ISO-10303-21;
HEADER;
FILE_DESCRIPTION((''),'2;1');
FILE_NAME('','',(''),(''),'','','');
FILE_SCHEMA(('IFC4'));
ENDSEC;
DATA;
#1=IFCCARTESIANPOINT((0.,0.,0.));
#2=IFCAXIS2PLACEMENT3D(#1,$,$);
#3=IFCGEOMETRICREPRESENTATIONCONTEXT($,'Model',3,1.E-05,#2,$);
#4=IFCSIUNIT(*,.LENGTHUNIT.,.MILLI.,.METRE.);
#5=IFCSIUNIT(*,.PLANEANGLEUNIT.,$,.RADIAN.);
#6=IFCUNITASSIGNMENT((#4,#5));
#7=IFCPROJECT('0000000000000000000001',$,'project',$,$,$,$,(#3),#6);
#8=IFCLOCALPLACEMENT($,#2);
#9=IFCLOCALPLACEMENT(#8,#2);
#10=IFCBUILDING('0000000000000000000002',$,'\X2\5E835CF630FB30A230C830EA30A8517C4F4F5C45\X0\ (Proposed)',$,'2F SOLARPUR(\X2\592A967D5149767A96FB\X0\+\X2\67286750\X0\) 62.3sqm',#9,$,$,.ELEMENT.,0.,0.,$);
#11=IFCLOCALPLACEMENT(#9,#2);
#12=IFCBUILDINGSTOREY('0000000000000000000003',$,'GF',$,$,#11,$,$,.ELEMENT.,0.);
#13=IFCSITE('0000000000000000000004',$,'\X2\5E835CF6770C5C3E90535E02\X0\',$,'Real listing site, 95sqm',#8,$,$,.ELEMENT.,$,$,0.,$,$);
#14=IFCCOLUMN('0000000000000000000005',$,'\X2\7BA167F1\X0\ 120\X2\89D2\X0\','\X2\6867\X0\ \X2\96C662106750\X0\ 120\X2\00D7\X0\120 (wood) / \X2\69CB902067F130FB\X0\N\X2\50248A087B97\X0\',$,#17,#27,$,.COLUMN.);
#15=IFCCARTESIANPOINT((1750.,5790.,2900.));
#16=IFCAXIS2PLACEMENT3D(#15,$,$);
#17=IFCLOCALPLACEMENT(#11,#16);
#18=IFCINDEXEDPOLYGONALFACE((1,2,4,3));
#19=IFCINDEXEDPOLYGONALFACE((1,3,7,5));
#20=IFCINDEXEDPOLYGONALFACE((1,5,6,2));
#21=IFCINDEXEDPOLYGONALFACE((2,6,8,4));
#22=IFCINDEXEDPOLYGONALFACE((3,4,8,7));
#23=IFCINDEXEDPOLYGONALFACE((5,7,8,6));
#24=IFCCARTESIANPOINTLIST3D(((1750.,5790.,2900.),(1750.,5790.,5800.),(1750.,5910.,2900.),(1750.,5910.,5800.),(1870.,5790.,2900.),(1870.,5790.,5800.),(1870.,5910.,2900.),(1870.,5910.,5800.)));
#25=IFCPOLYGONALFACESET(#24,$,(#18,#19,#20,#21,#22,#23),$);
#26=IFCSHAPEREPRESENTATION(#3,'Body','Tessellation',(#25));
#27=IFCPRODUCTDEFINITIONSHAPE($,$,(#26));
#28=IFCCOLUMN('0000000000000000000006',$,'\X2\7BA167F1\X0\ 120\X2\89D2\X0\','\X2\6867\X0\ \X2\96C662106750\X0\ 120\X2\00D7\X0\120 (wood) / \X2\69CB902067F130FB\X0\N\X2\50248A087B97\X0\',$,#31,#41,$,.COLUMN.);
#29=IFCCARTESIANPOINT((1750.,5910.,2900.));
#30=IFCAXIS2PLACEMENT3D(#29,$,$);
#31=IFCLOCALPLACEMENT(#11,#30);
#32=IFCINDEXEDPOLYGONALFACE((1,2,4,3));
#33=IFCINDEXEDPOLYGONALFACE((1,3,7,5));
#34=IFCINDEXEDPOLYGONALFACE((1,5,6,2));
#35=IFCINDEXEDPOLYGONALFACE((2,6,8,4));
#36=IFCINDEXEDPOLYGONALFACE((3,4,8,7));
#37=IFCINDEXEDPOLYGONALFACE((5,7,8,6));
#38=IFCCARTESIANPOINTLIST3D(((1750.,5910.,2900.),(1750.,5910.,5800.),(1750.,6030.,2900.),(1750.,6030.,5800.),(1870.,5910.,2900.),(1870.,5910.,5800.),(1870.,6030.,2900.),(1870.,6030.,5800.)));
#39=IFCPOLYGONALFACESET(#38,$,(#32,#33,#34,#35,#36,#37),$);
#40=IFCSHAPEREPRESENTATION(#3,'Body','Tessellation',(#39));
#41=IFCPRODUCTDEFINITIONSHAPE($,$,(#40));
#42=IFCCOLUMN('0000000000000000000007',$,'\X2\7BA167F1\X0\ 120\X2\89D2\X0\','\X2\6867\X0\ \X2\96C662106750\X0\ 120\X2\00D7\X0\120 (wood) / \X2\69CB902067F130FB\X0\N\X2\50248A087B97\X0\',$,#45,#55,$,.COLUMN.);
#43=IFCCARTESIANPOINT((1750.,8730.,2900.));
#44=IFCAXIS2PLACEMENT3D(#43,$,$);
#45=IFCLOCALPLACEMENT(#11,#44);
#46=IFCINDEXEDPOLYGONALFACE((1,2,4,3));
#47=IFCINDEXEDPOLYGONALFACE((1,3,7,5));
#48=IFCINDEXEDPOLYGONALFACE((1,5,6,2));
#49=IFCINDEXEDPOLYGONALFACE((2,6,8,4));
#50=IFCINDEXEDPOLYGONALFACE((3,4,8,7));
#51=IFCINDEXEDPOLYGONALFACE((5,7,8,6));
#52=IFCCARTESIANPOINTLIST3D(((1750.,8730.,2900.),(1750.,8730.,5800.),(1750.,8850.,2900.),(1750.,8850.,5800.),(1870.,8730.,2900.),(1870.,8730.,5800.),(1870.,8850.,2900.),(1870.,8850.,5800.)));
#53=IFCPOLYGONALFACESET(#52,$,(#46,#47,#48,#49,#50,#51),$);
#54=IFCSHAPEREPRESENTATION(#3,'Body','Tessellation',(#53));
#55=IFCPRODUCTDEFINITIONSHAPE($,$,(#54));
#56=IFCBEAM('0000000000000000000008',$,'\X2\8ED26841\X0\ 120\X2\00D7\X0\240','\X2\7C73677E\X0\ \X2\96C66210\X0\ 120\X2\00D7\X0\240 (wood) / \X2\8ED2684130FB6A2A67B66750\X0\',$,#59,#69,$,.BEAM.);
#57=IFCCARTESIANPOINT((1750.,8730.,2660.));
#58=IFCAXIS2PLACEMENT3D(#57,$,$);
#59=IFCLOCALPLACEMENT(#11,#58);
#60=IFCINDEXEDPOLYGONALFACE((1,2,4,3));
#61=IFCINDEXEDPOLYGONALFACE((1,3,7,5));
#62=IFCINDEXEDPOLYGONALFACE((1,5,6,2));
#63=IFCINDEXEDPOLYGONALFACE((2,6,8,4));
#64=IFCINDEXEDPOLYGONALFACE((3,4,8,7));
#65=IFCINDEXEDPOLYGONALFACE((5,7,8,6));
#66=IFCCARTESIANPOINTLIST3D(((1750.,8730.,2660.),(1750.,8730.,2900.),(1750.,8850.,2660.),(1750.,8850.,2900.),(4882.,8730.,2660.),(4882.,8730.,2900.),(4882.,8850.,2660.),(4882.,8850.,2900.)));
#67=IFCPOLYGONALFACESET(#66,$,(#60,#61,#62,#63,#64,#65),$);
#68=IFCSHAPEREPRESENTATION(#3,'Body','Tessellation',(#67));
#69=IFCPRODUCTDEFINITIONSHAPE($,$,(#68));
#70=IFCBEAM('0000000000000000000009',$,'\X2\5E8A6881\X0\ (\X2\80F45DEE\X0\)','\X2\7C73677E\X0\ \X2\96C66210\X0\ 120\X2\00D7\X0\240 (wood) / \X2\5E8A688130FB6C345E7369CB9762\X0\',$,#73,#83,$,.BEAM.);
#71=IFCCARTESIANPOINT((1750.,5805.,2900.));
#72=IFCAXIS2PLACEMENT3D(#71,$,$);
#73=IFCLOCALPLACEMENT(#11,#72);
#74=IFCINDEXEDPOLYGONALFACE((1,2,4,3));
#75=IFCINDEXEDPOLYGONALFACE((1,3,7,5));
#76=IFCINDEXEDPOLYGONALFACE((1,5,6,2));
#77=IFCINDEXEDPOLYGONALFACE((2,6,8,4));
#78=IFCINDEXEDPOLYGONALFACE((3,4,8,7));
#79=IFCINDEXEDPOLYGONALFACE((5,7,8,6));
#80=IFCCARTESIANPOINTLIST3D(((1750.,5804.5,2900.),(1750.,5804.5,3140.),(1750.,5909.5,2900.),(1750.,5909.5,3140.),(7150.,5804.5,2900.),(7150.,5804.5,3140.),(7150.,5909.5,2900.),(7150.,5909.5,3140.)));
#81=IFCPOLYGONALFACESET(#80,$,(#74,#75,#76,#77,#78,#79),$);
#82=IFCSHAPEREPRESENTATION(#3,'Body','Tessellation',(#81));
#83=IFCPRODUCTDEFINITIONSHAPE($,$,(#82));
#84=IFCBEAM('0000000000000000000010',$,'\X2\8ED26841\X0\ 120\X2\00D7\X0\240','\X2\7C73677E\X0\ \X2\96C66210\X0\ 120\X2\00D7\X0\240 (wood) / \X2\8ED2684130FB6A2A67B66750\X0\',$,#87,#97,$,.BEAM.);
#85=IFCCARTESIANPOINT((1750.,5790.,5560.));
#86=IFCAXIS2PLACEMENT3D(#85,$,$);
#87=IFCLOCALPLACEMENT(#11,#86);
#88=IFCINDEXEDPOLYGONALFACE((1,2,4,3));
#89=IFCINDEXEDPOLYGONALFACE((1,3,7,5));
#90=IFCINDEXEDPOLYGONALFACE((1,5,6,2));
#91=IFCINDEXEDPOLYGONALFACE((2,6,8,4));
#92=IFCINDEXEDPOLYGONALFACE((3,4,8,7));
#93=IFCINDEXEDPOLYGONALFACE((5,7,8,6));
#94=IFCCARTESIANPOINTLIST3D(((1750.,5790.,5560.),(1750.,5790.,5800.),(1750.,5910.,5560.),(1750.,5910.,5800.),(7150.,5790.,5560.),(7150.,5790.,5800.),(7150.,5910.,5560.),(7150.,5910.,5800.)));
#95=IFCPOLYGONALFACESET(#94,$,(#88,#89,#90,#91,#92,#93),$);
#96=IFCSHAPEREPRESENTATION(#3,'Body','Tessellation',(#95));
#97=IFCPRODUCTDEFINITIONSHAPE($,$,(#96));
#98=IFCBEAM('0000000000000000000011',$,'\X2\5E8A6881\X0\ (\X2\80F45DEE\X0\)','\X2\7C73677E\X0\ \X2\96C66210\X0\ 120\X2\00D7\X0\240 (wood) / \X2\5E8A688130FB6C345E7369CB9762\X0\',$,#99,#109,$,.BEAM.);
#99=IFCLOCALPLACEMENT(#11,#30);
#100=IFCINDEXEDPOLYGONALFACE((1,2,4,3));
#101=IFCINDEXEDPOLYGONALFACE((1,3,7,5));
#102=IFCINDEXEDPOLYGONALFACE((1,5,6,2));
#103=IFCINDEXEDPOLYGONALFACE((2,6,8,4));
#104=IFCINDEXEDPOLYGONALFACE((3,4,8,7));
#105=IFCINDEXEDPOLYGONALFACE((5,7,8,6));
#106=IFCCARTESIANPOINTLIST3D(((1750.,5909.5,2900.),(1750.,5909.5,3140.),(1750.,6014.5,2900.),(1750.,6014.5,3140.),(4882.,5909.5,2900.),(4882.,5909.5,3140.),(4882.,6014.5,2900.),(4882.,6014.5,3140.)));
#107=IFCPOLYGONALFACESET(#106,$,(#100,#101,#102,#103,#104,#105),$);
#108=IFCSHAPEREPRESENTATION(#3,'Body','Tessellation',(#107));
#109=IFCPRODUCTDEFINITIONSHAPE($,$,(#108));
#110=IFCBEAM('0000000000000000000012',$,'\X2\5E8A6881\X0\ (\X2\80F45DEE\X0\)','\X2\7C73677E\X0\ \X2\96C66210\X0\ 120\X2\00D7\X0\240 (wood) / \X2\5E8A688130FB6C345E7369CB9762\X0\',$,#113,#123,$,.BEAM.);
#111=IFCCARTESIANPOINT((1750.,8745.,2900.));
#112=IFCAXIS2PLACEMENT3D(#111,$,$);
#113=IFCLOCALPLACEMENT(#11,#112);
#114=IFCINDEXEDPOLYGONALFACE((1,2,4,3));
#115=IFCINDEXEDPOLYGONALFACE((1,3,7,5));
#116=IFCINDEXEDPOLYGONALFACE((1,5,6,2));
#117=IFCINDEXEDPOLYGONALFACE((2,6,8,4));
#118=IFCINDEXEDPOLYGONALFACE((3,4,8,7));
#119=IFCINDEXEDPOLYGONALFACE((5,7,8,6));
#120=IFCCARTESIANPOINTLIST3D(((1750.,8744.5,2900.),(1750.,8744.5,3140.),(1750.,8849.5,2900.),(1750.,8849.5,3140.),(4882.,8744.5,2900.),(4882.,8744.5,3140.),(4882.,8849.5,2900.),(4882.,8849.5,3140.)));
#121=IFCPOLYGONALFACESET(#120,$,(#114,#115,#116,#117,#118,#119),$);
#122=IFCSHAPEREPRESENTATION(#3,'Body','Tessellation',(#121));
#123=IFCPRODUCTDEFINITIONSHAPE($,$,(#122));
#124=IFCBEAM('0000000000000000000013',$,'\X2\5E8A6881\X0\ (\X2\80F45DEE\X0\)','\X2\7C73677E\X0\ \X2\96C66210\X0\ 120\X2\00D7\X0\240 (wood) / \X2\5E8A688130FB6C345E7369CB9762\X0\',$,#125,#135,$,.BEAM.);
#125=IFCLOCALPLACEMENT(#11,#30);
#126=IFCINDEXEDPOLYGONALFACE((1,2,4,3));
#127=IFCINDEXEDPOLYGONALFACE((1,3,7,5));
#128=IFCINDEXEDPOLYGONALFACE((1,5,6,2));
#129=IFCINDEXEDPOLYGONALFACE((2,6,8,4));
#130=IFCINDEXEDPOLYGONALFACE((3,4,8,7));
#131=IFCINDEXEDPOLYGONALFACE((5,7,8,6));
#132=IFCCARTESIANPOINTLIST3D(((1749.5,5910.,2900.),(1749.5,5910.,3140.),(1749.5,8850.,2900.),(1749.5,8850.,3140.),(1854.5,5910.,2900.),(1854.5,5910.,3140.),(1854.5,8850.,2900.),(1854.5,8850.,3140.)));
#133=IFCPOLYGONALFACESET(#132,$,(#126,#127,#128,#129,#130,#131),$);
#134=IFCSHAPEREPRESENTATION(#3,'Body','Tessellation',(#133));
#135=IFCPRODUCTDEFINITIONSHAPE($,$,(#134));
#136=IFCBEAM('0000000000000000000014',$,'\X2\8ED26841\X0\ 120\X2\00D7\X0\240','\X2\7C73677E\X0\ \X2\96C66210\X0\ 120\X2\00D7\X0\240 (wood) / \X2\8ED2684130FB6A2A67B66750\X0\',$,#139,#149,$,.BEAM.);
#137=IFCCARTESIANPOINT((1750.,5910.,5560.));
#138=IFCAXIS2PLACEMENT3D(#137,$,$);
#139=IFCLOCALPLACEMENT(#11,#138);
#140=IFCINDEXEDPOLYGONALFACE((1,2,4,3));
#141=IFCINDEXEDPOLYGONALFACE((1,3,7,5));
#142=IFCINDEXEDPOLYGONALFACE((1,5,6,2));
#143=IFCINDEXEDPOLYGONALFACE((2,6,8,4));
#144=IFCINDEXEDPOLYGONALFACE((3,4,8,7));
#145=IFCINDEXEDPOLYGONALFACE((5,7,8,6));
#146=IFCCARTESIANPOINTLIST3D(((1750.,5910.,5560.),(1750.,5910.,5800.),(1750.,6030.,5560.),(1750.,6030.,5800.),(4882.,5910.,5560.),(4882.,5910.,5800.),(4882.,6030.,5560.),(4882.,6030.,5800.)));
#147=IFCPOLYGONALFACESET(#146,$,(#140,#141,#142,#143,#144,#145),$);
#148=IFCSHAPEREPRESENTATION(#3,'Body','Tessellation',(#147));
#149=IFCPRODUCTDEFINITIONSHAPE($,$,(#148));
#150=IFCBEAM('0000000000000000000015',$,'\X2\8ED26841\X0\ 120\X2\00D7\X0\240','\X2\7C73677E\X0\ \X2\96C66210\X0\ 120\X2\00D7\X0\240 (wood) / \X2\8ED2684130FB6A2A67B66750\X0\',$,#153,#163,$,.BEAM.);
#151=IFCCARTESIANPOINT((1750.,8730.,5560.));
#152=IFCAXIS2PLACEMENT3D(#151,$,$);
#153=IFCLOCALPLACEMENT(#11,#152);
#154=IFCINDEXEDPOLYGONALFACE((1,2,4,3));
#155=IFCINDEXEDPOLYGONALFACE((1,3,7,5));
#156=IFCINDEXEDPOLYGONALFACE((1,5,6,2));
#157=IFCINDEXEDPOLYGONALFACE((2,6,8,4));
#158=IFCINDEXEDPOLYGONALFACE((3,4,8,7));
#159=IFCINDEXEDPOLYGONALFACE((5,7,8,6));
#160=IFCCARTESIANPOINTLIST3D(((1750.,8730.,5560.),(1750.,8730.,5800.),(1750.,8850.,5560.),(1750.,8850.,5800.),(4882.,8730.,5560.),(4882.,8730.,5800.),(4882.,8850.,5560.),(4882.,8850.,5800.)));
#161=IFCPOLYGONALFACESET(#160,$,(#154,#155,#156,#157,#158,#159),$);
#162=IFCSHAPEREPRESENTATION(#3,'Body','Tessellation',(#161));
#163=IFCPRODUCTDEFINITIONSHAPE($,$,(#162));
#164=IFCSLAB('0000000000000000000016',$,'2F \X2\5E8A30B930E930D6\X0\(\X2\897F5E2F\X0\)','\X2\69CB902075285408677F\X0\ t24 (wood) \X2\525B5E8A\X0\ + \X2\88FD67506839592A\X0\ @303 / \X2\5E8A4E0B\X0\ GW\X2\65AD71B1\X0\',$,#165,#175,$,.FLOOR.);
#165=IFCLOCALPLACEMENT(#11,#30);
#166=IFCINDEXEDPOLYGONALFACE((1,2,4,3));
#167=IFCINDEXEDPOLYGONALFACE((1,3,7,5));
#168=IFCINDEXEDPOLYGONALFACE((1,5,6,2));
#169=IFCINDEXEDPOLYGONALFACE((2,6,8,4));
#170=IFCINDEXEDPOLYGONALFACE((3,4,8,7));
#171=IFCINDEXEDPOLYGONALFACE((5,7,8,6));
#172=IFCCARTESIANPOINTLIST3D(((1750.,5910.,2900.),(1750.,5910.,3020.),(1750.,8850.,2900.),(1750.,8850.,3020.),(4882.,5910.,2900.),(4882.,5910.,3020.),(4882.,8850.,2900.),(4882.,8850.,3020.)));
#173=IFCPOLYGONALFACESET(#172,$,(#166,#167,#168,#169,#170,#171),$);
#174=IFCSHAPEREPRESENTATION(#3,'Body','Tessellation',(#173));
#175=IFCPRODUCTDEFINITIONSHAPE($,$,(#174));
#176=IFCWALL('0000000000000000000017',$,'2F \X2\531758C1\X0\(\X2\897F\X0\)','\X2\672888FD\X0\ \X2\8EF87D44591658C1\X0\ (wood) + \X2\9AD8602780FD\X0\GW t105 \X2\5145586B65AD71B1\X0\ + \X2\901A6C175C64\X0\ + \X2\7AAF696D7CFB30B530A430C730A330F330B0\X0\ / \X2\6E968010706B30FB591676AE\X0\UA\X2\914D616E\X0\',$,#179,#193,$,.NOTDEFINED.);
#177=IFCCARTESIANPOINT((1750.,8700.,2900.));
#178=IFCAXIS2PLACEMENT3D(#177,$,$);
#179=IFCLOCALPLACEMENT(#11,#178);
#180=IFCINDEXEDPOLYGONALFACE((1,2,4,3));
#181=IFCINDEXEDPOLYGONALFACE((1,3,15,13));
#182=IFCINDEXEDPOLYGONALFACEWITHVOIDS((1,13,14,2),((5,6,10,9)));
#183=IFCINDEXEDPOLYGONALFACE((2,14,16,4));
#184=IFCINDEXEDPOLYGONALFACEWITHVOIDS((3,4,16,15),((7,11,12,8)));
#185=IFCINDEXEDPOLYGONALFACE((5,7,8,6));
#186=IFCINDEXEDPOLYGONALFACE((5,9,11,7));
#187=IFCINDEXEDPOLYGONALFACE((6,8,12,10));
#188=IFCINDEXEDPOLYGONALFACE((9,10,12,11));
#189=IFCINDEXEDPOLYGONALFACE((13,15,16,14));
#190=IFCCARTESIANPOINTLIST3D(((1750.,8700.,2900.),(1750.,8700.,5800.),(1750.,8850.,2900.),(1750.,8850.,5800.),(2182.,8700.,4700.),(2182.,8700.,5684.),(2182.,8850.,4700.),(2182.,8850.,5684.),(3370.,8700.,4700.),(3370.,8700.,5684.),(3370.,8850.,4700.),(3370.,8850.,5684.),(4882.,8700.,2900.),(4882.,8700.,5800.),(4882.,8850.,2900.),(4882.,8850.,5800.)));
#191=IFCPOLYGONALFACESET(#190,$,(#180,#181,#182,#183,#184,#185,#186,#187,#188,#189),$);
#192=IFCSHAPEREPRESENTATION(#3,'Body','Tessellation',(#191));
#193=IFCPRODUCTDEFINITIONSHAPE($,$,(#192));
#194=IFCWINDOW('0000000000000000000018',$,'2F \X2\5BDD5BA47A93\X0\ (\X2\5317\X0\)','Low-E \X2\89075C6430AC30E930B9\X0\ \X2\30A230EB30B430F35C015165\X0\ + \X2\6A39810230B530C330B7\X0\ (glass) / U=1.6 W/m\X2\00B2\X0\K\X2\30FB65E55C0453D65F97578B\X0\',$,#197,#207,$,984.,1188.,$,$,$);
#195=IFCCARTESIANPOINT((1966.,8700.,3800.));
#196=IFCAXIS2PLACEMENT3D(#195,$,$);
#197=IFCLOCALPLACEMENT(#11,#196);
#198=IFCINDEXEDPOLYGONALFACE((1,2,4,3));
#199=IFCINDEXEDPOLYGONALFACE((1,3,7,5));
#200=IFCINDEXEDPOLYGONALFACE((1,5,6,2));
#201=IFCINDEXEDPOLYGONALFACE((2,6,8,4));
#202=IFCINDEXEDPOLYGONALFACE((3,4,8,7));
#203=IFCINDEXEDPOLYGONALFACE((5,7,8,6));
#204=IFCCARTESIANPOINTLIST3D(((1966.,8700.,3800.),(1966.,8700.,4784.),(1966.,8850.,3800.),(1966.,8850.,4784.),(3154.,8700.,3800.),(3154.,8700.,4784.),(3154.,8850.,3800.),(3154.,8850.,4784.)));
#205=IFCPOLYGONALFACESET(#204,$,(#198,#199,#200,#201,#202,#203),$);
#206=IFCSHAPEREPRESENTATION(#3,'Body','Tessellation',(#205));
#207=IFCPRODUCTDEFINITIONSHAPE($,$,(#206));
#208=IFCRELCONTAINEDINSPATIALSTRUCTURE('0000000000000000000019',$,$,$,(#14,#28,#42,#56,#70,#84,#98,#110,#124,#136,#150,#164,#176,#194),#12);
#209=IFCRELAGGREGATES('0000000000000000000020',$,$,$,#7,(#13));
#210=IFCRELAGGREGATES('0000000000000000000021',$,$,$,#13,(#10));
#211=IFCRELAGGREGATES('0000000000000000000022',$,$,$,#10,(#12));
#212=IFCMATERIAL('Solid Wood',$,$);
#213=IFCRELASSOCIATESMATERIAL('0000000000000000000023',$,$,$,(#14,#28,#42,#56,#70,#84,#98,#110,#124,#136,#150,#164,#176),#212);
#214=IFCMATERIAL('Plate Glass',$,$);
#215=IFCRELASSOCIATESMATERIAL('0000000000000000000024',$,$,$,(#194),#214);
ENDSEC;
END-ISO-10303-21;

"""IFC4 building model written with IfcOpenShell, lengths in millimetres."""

from ifc_helpers import new_model, si_unit, frame, frame_2d, origin, place, context, project, spatial, rectangle, extrude, material, element, fill, save


model = new_model("IFC4")

# Units and contexts
model_context = context("Model", 3, precision=1e-05, world=origin())
ifc_project = project(units=[si_unit("LENGTHUNIT", "METRE", prefix="MILLI"), si_unit("PLANEANGLEUNIT", "RADIAN")], contexts=[model_context])

# Site, building, storey
site_placement = place(None, origin())
site = spatial("IfcSite", under=ifc_project, at=site_placement, Name="広島県尾道市", ObjectType="Real listing site, 95sqm", CompositionType="ELEMENT", RefElevation=0.0)
building_placement = place(site_placement, origin())
building = spatial("IfcBuilding", under=site, at=building_placement, Name="広島・アトリエ兼住居 (Proposed)", ObjectType="2F SOLARPUR(太陽光発電+木材) 62.3sqm", CompositionType="ELEMENT", ElevationOfRefHeight=0.0, ElevationOfTerrain=0.0)
storey_placement = place(building_placement, origin())
storey = spatial("IfcBuildingStorey", under=building, at=storey_placement, Name="GF", CompositionType="ELEMENT", Elevation=0.0)

# Columns
ifc_material_1 = material(Name="Solid Wood")
column_1_placement = place(storey_placement, frame((1750.0, 5790.0, 2900.0)))
element("IfcColumn", 1, at=column_1_placement, inside=storey, material=ifc_material_1, Name="管柱 120角", Description="桧 集成材 120×120 (wood) / 構造柱・N値計算", PredefinedType="COLUMN", context=model_context, shape_type="SweptSolid", body=[
    extrude(rectangle(XDim=120.0, YDim=120.0, at=frame_2d((60.0, 60.0))), frame((1750.0, 5790.0, 2900.0)), (0.0, 0.0, 1.0), 2900.0),
])
column_2_placement = place(storey_placement, frame((1750.0, 5910.0, 2900.0)))
element("IfcColumn", 2, at=column_2_placement, inside=storey, material=ifc_material_1, Name="管柱 120角", Description="桧 集成材 120×120 (wood) / 構造柱・N値計算", PredefinedType="COLUMN", context=model_context, shape_type="SweptSolid", body=[
    extrude(rectangle(XDim=120.0, YDim=120.0, at=frame_2d((60.0, 60.0))), frame((1750.0, 5910.0, 2900.0)), (0.0, 0.0, 1.0), 2900.0),
])
column_3_placement = place(storey_placement, frame((1750.0, 8730.0, 2900.0)))
element("IfcColumn", 3, at=column_3_placement, inside=storey, material=ifc_material_1, Name="管柱 120角", Description="桧 集成材 120×120 (wood) / 構造柱・N値計算", PredefinedType="COLUMN", context=model_context, shape_type="SweptSolid", body=[
    extrude(rectangle(XDim=120.0, YDim=120.0, at=frame_2d((60.0, 60.0))), frame((1750.0, 8730.0, 2900.0)), (0.0, 0.0, 1.0), 2900.0),
])

# Beams
beam_1_placement = place(storey_placement, frame((1750.0, 8730.0, 2660.0)))
element("IfcBeam", 4, at=beam_1_placement, inside=storey, material=ifc_material_1, Name="軒桁 120×240", Description="米松 集成 120×240 (wood) / 軒桁・横架材", PredefinedType="BEAM", context=model_context, shape_type="SweptSolid", body=[
    extrude(rectangle(XDim=3132.0, YDim=120.0, at=frame_2d((1566.0, 60.0))), frame((1750.0, 8730.0, 2660.0)), (0.0, 0.0, 1.0), 240.0),
])
beam_2_placement = place(storey_placement, frame((1750.0, 5805.0, 2900.0)))
element("IfcBeam", 5, at=beam_2_placement, inside=storey, material=ifc_material_1, Name="床梁 (胴差)", Description="米松 集成 120×240 (wood) / 床梁・水平構面", PredefinedType="BEAM", context=model_context, shape_type="SweptSolid", body=[
    extrude(rectangle(XDim=5400.0, YDim=105.0, at=frame_2d((2700.0, 52.0))), frame((1750.0, 5805.0, 2900.0)), (0.0, 0.0, 1.0), 240.0),
])
beam_3_placement = place(storey_placement, frame((1750.0, 5790.0, 5560.0)))
element("IfcBeam", 6, at=beam_3_placement, inside=storey, material=ifc_material_1, Name="軒桁 120×240", Description="米松 集成 120×240 (wood) / 軒桁・横架材", PredefinedType="BEAM", context=model_context, shape_type="SweptSolid", body=[
    extrude(rectangle(XDim=5400.0, YDim=120.0, at=frame_2d((2700.0, 60.0))), frame((1750.0, 5790.0, 5560.0)), (0.0, 0.0, 1.0), 240.0),
])
beam_4_placement = place(storey_placement, frame((1750.0, 5910.0, 2900.0)))
element("IfcBeam", 7, at=beam_4_placement, inside=storey, material=ifc_material_1, Name="床梁 (胴差)", Description="米松 集成 120×240 (wood) / 床梁・水平構面", PredefinedType="BEAM", context=model_context, shape_type="SweptSolid", body=[
    extrude(rectangle(XDim=3132.0, YDim=105.0, at=frame_2d((1566.0, 52.0))), frame((1750.0, 5910.0, 2900.0)), (0.0, 0.0, 1.0), 240.0),
])
beam_5_placement = place(storey_placement, frame((1750.0, 8745.0, 2900.0)))
element("IfcBeam", 8, at=beam_5_placement, inside=storey, material=ifc_material_1, Name="床梁 (胴差)", Description="米松 集成 120×240 (wood) / 床梁・水平構面", PredefinedType="BEAM", context=model_context, shape_type="SweptSolid", body=[
    extrude(rectangle(XDim=3132.0, YDim=105.0, at=frame_2d((1566.0, 52.0))), frame((1750.0, 8745.0, 2900.0)), (0.0, 0.0, 1.0), 240.0),
])
beam_6_placement = place(storey_placement, frame((1750.0, 5910.0, 2900.0)))
element("IfcBeam", 9, at=beam_6_placement, inside=storey, material=ifc_material_1, Name="床梁 (胴差)", Description="米松 集成 120×240 (wood) / 床梁・水平構面", PredefinedType="BEAM", context=model_context, shape_type="SweptSolid", body=[
    extrude(rectangle(XDim=105.0, YDim=2940.0, at=frame_2d((52.0, 1470.0))), frame((1750.0, 5910.0, 2900.0)), (0.0, 0.0, 1.0), 240.0),
])
beam_7_placement = place(storey_placement, frame((1750.0, 5910.0, 5560.0)))
element("IfcBeam", 10, at=beam_7_placement, inside=storey, material=ifc_material_1, Name="軒桁 120×240", Description="米松 集成 120×240 (wood) / 軒桁・横架材", PredefinedType="BEAM", context=model_context, shape_type="SweptSolid", body=[
    extrude(rectangle(XDim=3132.0, YDim=120.0, at=frame_2d((1566.0, 60.0))), frame((1750.0, 5910.0, 5560.0)), (0.0, 0.0, 1.0), 240.0),
])
beam_8_placement = place(storey_placement, frame((1750.0, 8730.0, 5560.0)))
element("IfcBeam", 11, at=beam_8_placement, inside=storey, material=ifc_material_1, Name="軒桁 120×240", Description="米松 集成 120×240 (wood) / 軒桁・横架材", PredefinedType="BEAM", context=model_context, shape_type="SweptSolid", body=[
    extrude(rectangle(XDim=3132.0, YDim=120.0, at=frame_2d((1566.0, 60.0))), frame((1750.0, 8730.0, 5560.0)), (0.0, 0.0, 1.0), 240.0),
])

# Slab
slab_placement = place(storey_placement, frame((1750.0, 5910.0, 2900.0)))
element("IfcSlab", 12, at=slab_placement, inside=storey, material=ifc_material_1, Name="2F 床スラブ(西帯)", Description="構造用合板 t24 (wood) 剛床 + 製材根太 @303 / 床下 GW断熱", PredefinedType="FLOOR", context=model_context, shape_type="SweptSolid", body=[
    extrude(rectangle(XDim=3132.0, YDim=2940.0, at=frame_2d((1566.0, 1470.0))), frame((1750.0, 5910.0, 2900.0)), (0.0, 0.0, 1.0), 120.0),
])

# Wall, opening, window
wall_1_placement = place(storey_placement, frame((1750.0, 8700.0, 2900.0)))
wall_1 = element("IfcWall", 13, at=wall_1_placement, inside=storey, material=ifc_material_1, Name="2F 北壁(西)", Description="木製 軸組外壁 (wood) + 高性能GW t105 充填断熱 + 通気層 + 窯業系サイディング / 準耐火・外皮UA配慮", PredefinedType="NOTDEFINED", context=model_context, shape_type="SweptSolid", body=[
    extrude(rectangle(XDim=3132.0, YDim=150.0, at=frame_2d((1566.0, 75.0))), frame((1750.0, 8700.0, 2900.0)), (0.0, 0.0, 1.0), 2900.0),
])
opening_placement = place(storey_placement, frame((1966.0, 8700.0, 3800.0)))
opening = element("IfcOpeningElement", 14, at=opening_placement, cuts=wall_1, PredefinedType="NOTDEFINED", context=model_context, shape_type="SweptSolid", body=[
    extrude(rectangle(XDim=1188.0, YDim=150.0, at=frame_2d((594.0, 75.0))), frame((1966.0, 8700.0, 3800.0)), (0.0, 0.0, 1.0), 984.0),
])
ifc_material_2 = material(Name="Plate Glass")
window_placement = place(storey_placement, frame((1966.0, 8700.0, 3800.0)))
window = element("IfcWindow", 15, at=window_placement, inside=storey, material=ifc_material_2, Name="2F 寝室窓 (北)", Description="Low-E 複層ガラス アルゴン封入 + 樹脂サッシ (glass) / U=1.6 W/m²K・日射取得型", OverallHeight=984.0, OverallWidth=1188.0, context=model_context, shape_type="SweptSolid", body=[
    extrude(rectangle(XDim=1188.0, YDim=150.0, at=frame_2d((594.0, 75.0))), frame((1966.0, 8700.0, 3800.0)), (0.0, 0.0, 1.0), 984.0),
])
fill(opening, window)

save(model, "model.ifc")
